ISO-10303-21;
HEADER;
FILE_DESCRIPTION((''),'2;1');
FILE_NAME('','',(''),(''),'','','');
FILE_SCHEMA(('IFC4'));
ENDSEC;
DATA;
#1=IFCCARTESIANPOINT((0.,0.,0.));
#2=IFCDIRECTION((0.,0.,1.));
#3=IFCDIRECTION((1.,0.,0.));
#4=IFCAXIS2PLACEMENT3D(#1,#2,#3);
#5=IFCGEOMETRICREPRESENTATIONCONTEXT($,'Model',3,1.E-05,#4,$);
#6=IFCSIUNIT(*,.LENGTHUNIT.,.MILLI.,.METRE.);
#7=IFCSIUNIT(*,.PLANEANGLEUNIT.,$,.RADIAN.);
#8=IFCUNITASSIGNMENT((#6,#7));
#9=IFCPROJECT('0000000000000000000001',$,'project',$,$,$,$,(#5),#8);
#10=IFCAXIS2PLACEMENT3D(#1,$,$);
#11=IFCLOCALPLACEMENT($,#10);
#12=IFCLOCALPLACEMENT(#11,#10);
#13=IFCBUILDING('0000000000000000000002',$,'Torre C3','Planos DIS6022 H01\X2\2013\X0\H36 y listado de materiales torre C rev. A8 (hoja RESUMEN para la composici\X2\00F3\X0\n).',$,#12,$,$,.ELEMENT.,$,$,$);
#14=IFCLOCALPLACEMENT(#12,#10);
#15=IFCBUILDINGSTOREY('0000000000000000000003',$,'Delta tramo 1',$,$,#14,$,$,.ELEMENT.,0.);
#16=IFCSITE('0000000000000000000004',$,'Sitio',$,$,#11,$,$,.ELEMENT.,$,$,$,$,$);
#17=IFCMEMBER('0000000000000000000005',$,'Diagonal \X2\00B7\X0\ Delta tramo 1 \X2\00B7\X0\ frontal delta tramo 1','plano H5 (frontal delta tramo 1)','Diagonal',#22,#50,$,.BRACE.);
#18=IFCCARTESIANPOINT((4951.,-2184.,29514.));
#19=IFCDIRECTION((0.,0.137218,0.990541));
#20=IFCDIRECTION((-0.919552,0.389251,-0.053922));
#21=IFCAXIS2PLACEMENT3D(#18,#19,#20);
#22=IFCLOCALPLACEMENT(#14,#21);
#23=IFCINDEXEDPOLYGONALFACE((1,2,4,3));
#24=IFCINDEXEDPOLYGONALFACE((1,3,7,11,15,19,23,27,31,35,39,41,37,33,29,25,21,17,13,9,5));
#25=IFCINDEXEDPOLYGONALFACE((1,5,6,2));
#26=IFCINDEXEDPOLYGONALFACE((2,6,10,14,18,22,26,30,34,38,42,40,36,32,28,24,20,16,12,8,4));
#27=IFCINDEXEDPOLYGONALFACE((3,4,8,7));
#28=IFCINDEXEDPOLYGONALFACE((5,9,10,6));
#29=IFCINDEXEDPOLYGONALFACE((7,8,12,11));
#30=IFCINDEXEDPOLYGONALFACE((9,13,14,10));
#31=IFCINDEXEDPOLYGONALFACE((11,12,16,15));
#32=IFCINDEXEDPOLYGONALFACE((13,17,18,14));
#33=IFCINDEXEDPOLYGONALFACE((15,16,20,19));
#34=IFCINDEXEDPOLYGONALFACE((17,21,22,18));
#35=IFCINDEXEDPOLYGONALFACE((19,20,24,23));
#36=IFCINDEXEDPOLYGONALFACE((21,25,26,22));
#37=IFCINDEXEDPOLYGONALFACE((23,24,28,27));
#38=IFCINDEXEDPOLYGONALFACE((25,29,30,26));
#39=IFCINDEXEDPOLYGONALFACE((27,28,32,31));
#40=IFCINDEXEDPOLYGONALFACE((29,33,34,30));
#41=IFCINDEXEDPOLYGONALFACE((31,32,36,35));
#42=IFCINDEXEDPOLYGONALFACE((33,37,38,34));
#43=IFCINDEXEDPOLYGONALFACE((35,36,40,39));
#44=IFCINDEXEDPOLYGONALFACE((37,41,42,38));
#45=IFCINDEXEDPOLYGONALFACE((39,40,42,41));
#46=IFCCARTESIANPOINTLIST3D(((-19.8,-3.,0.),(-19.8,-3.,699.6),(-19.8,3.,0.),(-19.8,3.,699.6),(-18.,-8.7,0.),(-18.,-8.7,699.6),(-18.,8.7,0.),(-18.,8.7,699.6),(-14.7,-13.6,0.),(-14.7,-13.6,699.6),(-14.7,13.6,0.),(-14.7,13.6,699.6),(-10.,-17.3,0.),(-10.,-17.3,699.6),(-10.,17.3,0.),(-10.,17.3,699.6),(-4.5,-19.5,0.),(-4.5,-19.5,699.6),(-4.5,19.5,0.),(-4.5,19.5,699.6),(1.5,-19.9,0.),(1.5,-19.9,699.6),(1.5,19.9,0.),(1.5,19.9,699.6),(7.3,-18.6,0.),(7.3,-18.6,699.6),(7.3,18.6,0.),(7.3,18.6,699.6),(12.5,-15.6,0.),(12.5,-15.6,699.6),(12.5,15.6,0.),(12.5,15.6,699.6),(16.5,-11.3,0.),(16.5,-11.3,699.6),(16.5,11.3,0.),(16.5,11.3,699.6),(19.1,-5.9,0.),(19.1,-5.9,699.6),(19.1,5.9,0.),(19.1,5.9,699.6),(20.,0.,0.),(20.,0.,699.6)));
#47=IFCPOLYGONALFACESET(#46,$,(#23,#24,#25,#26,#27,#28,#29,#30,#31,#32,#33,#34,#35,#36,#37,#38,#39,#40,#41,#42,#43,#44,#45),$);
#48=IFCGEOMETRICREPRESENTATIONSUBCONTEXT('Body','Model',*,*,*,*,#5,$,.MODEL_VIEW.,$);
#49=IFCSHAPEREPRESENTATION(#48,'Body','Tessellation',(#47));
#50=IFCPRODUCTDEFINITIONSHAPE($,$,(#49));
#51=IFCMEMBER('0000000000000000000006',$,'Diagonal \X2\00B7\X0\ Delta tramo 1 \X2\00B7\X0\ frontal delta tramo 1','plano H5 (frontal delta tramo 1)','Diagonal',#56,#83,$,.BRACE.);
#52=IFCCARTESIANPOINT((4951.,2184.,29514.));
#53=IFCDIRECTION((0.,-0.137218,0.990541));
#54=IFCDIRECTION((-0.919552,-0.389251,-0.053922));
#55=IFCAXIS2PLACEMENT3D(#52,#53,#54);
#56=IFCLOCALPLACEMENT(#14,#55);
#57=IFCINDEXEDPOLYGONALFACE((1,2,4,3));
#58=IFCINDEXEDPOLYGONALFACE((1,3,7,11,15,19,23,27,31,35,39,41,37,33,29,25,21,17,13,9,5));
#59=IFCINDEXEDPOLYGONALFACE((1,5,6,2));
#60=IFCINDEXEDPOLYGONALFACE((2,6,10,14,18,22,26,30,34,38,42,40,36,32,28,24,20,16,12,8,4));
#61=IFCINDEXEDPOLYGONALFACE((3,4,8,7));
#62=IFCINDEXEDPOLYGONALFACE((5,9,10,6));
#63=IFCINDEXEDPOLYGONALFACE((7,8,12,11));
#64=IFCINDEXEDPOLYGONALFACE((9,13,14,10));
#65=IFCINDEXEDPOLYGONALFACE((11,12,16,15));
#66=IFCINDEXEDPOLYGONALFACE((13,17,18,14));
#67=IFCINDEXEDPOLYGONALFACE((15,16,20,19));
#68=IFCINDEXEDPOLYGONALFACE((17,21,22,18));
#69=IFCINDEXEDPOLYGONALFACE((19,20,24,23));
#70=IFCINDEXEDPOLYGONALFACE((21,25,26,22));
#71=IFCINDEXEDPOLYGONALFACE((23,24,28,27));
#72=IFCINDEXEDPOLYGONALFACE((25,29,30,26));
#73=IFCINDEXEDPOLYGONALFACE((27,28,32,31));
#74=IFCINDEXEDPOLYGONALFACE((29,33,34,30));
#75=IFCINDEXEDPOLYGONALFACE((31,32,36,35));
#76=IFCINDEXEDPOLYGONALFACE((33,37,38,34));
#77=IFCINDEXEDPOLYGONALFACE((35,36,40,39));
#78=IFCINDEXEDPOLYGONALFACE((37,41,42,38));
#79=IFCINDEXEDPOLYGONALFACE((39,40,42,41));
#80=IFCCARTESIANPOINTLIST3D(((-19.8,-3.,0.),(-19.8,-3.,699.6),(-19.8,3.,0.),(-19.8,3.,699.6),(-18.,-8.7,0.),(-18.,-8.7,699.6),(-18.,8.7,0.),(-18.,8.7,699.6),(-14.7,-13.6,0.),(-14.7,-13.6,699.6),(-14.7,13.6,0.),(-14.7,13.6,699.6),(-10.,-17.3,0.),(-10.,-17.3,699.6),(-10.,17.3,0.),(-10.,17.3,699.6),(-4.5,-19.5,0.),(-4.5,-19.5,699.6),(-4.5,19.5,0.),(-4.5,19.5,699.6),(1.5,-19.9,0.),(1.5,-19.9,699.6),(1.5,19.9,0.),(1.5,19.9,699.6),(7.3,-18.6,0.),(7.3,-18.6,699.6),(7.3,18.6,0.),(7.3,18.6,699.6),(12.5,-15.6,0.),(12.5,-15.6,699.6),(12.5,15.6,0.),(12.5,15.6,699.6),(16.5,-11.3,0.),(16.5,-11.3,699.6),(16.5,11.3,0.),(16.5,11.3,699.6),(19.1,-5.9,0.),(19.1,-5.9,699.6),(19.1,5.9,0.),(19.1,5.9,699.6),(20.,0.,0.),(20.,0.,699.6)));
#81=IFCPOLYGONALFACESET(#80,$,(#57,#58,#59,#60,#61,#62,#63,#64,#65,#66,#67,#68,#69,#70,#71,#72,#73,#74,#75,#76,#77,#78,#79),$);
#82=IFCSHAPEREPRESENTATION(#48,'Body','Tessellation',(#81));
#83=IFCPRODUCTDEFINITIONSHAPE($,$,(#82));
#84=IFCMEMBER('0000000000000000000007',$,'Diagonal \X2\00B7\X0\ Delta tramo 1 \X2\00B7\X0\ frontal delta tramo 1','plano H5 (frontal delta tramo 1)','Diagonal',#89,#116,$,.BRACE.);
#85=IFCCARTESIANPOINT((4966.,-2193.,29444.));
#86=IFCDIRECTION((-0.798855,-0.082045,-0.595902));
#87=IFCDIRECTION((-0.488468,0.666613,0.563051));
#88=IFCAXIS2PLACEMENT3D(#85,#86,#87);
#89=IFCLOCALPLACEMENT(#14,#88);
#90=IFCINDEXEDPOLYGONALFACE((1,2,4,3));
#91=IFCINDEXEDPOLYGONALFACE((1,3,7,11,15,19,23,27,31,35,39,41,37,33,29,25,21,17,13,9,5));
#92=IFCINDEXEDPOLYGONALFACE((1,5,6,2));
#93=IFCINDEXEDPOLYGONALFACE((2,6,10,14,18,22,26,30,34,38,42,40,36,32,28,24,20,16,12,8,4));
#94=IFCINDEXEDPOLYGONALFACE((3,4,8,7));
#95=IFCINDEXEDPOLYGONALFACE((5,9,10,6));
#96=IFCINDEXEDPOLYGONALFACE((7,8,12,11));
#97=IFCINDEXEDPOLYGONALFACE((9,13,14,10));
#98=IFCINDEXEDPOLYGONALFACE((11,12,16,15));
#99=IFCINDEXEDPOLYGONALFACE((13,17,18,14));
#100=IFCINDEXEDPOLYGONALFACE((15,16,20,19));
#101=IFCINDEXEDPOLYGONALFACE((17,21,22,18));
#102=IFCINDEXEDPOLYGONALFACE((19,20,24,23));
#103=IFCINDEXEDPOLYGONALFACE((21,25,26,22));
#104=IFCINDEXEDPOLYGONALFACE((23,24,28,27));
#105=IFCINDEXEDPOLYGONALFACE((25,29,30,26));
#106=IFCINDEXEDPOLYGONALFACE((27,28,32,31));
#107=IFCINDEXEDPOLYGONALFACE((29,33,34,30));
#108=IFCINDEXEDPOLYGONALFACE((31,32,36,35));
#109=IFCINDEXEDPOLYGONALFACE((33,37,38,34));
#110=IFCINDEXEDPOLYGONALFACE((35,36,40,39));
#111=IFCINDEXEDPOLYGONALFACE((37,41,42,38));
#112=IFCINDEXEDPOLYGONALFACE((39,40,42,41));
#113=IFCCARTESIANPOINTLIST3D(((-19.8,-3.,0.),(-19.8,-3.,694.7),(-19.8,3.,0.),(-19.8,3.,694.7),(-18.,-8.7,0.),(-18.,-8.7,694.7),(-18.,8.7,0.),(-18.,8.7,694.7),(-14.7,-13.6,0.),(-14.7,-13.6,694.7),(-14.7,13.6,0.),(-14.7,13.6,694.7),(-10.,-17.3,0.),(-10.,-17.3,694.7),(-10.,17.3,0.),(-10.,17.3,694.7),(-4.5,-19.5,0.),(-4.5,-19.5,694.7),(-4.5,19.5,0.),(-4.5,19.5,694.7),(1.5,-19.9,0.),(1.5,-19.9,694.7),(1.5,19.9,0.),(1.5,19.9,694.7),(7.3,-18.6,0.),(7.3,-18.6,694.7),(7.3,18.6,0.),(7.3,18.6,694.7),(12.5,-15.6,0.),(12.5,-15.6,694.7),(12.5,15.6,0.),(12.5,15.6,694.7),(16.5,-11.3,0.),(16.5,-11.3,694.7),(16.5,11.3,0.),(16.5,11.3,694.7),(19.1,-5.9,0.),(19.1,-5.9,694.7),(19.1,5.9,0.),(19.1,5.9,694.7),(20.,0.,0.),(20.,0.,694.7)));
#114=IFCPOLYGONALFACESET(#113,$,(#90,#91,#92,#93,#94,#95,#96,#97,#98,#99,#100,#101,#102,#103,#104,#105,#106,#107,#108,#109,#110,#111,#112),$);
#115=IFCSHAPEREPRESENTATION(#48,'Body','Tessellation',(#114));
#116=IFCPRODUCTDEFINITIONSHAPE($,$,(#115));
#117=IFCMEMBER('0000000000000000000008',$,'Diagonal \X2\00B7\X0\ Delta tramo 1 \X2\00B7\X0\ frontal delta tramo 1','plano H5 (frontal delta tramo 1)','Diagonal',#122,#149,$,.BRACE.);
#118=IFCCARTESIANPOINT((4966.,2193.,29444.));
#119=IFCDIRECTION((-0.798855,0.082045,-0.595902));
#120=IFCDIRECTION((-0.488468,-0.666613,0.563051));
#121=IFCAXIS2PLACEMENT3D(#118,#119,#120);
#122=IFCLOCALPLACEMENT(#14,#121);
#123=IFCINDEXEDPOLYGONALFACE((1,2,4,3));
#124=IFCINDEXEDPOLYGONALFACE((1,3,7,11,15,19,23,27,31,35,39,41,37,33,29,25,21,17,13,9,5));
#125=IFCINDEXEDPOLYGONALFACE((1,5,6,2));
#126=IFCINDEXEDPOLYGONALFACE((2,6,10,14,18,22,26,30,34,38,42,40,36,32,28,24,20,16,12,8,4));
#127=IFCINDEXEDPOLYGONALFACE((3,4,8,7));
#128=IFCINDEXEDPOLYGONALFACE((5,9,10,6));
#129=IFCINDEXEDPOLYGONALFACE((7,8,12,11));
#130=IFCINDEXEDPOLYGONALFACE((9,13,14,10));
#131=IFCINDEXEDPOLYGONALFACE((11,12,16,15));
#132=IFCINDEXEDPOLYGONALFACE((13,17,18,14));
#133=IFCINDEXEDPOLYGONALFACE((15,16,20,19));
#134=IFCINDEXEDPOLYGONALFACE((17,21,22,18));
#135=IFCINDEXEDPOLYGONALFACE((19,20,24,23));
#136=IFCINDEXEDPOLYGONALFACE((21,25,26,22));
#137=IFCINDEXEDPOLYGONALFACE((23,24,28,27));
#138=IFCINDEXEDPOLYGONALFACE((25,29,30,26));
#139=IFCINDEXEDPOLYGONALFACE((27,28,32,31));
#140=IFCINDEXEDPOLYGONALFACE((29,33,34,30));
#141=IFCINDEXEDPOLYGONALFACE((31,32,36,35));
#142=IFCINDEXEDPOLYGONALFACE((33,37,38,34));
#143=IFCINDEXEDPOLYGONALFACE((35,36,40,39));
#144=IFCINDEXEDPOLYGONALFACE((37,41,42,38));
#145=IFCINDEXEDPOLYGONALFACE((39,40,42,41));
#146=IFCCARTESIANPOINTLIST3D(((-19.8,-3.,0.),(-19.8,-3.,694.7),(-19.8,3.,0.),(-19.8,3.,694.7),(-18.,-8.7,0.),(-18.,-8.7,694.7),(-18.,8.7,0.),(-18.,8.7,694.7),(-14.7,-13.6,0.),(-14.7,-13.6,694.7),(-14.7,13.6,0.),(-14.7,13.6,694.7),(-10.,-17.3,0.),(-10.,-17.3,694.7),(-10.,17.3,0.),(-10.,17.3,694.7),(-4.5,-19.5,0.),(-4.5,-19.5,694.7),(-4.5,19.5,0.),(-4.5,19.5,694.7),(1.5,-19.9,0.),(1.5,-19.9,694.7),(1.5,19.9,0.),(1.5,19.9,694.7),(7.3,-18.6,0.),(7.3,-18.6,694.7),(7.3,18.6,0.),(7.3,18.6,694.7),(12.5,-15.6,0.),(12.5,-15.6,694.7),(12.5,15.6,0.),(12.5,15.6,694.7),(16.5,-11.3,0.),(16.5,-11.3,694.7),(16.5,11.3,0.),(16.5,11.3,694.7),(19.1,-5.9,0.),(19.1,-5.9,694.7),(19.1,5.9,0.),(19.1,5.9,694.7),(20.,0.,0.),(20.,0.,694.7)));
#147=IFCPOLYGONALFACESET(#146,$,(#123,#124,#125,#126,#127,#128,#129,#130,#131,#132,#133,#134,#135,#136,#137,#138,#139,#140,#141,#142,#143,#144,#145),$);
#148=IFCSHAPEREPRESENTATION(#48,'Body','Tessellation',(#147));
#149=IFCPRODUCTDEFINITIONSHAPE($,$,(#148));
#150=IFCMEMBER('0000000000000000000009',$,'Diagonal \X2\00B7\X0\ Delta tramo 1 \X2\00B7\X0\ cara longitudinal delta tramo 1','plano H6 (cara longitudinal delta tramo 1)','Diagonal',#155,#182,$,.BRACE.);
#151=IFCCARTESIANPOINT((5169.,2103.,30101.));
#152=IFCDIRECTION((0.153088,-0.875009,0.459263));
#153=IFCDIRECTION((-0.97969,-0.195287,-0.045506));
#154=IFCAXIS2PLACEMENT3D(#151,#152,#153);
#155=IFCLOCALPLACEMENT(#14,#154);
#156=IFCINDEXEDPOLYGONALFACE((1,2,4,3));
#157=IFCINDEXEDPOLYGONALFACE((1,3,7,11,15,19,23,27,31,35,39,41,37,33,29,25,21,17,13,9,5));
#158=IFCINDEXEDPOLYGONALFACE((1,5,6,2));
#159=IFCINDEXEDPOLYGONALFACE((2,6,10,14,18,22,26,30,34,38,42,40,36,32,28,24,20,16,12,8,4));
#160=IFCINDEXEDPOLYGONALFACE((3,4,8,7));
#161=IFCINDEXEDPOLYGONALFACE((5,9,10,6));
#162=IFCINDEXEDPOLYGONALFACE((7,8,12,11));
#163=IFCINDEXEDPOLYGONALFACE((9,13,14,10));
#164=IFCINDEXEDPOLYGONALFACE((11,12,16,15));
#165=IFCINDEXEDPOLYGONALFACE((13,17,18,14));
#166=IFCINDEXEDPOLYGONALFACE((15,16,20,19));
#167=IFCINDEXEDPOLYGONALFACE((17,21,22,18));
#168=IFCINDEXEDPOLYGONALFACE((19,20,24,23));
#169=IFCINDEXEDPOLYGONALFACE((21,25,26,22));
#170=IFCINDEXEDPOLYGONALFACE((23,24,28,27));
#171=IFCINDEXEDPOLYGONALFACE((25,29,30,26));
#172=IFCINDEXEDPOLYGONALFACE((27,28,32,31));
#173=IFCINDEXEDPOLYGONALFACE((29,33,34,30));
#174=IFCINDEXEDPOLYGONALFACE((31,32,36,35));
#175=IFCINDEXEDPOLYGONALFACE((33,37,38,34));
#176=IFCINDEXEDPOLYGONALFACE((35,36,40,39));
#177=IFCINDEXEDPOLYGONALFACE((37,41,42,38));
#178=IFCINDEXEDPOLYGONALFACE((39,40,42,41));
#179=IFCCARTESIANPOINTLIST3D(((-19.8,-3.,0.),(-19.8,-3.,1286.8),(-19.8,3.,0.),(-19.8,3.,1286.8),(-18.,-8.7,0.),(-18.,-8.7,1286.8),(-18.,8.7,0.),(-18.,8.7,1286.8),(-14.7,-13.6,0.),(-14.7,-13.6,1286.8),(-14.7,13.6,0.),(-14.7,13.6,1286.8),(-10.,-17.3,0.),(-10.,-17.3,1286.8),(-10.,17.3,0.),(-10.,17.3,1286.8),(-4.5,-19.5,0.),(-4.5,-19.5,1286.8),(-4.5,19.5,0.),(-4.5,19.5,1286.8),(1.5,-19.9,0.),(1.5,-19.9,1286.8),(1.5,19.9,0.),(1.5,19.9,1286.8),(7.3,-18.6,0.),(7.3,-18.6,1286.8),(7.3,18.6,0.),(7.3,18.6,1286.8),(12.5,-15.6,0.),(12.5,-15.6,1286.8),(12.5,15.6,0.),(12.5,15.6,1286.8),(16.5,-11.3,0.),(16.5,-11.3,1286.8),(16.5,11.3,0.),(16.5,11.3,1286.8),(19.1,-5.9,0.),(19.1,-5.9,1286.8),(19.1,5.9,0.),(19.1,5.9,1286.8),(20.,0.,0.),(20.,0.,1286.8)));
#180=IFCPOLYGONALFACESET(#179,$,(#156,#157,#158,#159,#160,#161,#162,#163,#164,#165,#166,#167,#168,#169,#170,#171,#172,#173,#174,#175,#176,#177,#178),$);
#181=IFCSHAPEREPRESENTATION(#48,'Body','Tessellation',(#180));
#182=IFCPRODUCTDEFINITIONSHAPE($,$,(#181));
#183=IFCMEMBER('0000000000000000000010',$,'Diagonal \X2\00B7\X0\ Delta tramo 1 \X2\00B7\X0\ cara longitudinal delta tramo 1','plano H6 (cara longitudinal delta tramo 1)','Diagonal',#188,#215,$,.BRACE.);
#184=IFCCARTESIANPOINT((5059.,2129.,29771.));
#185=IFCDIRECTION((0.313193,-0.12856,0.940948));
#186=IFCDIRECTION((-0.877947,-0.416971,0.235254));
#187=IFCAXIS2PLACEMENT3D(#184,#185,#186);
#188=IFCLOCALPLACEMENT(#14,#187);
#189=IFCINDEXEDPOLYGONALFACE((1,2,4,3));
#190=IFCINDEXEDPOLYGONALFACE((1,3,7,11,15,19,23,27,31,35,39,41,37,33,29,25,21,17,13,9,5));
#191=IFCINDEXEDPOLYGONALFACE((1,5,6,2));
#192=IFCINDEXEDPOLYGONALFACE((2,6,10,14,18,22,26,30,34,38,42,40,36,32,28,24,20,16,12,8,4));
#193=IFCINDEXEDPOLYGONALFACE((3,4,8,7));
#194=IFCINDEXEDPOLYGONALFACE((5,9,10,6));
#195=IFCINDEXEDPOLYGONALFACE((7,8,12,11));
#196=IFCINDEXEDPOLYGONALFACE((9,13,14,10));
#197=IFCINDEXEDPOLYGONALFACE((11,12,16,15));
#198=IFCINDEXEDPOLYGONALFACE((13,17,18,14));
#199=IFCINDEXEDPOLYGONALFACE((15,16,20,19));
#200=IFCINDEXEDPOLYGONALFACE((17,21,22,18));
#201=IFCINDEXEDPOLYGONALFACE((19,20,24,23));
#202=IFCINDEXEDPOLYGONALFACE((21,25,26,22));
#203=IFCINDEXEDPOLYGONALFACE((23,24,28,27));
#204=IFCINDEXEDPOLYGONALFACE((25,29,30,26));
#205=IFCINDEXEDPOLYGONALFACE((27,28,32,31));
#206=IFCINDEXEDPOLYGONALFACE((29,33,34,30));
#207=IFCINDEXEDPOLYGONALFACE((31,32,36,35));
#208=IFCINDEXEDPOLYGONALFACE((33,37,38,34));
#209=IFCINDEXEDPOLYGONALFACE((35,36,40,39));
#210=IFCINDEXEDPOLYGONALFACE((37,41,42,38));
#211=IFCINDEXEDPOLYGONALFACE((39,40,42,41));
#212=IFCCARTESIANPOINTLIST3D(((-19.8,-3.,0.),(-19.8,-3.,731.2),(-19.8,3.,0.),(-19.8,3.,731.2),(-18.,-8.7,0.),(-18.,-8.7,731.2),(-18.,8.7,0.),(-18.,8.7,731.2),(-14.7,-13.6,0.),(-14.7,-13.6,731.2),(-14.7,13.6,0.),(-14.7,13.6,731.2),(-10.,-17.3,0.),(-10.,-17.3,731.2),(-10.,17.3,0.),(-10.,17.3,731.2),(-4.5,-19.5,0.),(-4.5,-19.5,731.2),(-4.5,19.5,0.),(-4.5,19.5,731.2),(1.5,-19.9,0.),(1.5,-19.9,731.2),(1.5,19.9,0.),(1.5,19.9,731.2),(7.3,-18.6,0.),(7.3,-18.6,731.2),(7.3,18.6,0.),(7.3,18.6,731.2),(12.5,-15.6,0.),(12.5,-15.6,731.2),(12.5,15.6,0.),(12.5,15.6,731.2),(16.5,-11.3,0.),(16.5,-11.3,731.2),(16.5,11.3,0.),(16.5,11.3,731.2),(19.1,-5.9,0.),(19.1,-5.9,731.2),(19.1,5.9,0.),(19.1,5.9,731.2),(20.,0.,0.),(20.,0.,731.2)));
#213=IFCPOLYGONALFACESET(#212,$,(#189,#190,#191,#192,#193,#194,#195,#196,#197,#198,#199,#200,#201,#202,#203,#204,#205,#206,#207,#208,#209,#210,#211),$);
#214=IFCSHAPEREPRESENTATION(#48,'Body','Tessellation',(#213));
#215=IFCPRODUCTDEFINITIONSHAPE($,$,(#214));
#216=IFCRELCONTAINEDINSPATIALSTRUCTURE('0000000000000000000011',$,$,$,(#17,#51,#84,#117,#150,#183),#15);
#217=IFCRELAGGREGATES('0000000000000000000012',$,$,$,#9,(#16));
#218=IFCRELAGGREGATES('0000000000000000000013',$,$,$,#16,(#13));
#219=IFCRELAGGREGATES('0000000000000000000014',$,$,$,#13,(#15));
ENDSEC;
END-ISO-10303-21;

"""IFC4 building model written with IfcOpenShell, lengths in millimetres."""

from ifc_helpers import new_model, si_unit, frame, origin, origin_with_axes, place, context, subcontext, project, spatial, circle, extrude, element, save


model = new_model("IFC4")

# Units and contexts
model_context = context("Model", 3, precision=1e-05, world=origin_with_axes())
body_context = subcontext(model_context, "Body", "Model", "MODEL_VIEW")
ifc_project = project(units=[si_unit("LENGTHUNIT", "METRE", prefix="MILLI"), si_unit("PLANEANGLEUNIT", "RADIAN")], contexts=[model_context])

# Site, building, storey
site_placement = place(None, origin())
site = spatial("IfcSite", under=ifc_project, at=site_placement, Name="Sitio", CompositionType="ELEMENT")
building_placement = place(site_placement, origin())
building = spatial("IfcBuilding", under=site, at=building_placement, Name="Torre C3", Description="Planos DIS6022 H01–H36 y listado de materiales torre C rev. A8 (hoja RESUMEN para la composición).", CompositionType="ELEMENT")
storey_placement = place(building_placement, origin())
storey = spatial("IfcBuildingStorey", under=building, at=storey_placement, Name="Delta tramo 1", CompositionType="ELEMENT", Elevation=0.0)

# Members
for number, where, z_axis, x_axis, name in (
    (1, (4951.0, -2184.0, 29514.0), (0.0, 0.137218, 0.990541), (-0.919552, 0.389251, -0.053922), "Diagonal · Delta tramo 1 · frontal delta tramo 1"),
    (2, (4951.0, 2184.0, 29514.0), (0.0, -0.137218, 0.990541), (-0.919552, -0.389251, -0.053922), "Diagonal · Delta tramo 1 · frontal delta tramo 1"),
):
    element("IfcMember", number, at=place(storey_placement, frame(where, z_axis=z_axis, x_axis=x_axis)), inside=storey, Name=name, Description="plano H5 (frontal delta tramo 1)", ObjectType="Diagonal", PredefinedType="BRACE", context=body_context, shape_type="SweptSolid", body=[
        extrude(circle(Radius=20.0), None, (0.0, 0.0, 1.0), 699.6),
    ])
for number, where, z_axis, x_axis, name in (
    (3, (4966.0, -2193.0, 29444.0), (-0.798855, -0.082045, -0.595902), (-0.488468, 0.666613, 0.563051), "Diagonal · Delta tramo 1 · frontal delta tramo 1"),
    (4, (4966.0, 2193.0, 29444.0), (-0.798855, 0.082045, -0.595902), (-0.488468, -0.666613, 0.563051), "Diagonal · Delta tramo 1 · frontal delta tramo 1"),
):
    element("IfcMember", number, at=place(storey_placement, frame(where, z_axis=z_axis, x_axis=x_axis)), inside=storey, Name=name, Description="plano H5 (frontal delta tramo 1)", ObjectType="Diagonal", PredefinedType="BRACE", context=body_context, shape_type="SweptSolid", body=[
        extrude(circle(Radius=20.0), None, (0.0, 0.0, 1.0), 694.7),
    ])
member_1_placement = place(storey_placement, frame((5169.0, 2103.0, 30101.0), z_axis=(0.153088, -0.875009, 0.459263), x_axis=(-0.97969, -0.195287, -0.045506)))
element("IfcMember", 5, at=member_1_placement, inside=storey, Name="Diagonal · Delta tramo 1 · cara longitudinal delta tramo 1", Description="plano H6 (cara longitudinal delta tramo 1)", ObjectType="Diagonal", PredefinedType="BRACE", context=body_context, shape_type="SweptSolid", body=[
    extrude(circle(Radius=20.0), None, (0.0, 0.0, 1.0), 1286.8),
])
member_2_placement = place(storey_placement, frame((5059.0, 2129.0, 29771.0), z_axis=(0.313193, -0.12856, 0.940948), x_axis=(-0.877947, -0.416971, 0.235254)))
element("IfcMember", 6, at=member_2_placement, inside=storey, Name="Diagonal · Delta tramo 1 · cara longitudinal delta tramo 1", Description="plano H6 (cara longitudinal delta tramo 1)", ObjectType="Diagonal", PredefinedType="BRACE", context=body_context, shape_type="SweptSolid", body=[
    extrude(circle(Radius=20.0), None, (0.0, 0.0, 1.0), 731.2),
])

save(model, "model.ifc")
